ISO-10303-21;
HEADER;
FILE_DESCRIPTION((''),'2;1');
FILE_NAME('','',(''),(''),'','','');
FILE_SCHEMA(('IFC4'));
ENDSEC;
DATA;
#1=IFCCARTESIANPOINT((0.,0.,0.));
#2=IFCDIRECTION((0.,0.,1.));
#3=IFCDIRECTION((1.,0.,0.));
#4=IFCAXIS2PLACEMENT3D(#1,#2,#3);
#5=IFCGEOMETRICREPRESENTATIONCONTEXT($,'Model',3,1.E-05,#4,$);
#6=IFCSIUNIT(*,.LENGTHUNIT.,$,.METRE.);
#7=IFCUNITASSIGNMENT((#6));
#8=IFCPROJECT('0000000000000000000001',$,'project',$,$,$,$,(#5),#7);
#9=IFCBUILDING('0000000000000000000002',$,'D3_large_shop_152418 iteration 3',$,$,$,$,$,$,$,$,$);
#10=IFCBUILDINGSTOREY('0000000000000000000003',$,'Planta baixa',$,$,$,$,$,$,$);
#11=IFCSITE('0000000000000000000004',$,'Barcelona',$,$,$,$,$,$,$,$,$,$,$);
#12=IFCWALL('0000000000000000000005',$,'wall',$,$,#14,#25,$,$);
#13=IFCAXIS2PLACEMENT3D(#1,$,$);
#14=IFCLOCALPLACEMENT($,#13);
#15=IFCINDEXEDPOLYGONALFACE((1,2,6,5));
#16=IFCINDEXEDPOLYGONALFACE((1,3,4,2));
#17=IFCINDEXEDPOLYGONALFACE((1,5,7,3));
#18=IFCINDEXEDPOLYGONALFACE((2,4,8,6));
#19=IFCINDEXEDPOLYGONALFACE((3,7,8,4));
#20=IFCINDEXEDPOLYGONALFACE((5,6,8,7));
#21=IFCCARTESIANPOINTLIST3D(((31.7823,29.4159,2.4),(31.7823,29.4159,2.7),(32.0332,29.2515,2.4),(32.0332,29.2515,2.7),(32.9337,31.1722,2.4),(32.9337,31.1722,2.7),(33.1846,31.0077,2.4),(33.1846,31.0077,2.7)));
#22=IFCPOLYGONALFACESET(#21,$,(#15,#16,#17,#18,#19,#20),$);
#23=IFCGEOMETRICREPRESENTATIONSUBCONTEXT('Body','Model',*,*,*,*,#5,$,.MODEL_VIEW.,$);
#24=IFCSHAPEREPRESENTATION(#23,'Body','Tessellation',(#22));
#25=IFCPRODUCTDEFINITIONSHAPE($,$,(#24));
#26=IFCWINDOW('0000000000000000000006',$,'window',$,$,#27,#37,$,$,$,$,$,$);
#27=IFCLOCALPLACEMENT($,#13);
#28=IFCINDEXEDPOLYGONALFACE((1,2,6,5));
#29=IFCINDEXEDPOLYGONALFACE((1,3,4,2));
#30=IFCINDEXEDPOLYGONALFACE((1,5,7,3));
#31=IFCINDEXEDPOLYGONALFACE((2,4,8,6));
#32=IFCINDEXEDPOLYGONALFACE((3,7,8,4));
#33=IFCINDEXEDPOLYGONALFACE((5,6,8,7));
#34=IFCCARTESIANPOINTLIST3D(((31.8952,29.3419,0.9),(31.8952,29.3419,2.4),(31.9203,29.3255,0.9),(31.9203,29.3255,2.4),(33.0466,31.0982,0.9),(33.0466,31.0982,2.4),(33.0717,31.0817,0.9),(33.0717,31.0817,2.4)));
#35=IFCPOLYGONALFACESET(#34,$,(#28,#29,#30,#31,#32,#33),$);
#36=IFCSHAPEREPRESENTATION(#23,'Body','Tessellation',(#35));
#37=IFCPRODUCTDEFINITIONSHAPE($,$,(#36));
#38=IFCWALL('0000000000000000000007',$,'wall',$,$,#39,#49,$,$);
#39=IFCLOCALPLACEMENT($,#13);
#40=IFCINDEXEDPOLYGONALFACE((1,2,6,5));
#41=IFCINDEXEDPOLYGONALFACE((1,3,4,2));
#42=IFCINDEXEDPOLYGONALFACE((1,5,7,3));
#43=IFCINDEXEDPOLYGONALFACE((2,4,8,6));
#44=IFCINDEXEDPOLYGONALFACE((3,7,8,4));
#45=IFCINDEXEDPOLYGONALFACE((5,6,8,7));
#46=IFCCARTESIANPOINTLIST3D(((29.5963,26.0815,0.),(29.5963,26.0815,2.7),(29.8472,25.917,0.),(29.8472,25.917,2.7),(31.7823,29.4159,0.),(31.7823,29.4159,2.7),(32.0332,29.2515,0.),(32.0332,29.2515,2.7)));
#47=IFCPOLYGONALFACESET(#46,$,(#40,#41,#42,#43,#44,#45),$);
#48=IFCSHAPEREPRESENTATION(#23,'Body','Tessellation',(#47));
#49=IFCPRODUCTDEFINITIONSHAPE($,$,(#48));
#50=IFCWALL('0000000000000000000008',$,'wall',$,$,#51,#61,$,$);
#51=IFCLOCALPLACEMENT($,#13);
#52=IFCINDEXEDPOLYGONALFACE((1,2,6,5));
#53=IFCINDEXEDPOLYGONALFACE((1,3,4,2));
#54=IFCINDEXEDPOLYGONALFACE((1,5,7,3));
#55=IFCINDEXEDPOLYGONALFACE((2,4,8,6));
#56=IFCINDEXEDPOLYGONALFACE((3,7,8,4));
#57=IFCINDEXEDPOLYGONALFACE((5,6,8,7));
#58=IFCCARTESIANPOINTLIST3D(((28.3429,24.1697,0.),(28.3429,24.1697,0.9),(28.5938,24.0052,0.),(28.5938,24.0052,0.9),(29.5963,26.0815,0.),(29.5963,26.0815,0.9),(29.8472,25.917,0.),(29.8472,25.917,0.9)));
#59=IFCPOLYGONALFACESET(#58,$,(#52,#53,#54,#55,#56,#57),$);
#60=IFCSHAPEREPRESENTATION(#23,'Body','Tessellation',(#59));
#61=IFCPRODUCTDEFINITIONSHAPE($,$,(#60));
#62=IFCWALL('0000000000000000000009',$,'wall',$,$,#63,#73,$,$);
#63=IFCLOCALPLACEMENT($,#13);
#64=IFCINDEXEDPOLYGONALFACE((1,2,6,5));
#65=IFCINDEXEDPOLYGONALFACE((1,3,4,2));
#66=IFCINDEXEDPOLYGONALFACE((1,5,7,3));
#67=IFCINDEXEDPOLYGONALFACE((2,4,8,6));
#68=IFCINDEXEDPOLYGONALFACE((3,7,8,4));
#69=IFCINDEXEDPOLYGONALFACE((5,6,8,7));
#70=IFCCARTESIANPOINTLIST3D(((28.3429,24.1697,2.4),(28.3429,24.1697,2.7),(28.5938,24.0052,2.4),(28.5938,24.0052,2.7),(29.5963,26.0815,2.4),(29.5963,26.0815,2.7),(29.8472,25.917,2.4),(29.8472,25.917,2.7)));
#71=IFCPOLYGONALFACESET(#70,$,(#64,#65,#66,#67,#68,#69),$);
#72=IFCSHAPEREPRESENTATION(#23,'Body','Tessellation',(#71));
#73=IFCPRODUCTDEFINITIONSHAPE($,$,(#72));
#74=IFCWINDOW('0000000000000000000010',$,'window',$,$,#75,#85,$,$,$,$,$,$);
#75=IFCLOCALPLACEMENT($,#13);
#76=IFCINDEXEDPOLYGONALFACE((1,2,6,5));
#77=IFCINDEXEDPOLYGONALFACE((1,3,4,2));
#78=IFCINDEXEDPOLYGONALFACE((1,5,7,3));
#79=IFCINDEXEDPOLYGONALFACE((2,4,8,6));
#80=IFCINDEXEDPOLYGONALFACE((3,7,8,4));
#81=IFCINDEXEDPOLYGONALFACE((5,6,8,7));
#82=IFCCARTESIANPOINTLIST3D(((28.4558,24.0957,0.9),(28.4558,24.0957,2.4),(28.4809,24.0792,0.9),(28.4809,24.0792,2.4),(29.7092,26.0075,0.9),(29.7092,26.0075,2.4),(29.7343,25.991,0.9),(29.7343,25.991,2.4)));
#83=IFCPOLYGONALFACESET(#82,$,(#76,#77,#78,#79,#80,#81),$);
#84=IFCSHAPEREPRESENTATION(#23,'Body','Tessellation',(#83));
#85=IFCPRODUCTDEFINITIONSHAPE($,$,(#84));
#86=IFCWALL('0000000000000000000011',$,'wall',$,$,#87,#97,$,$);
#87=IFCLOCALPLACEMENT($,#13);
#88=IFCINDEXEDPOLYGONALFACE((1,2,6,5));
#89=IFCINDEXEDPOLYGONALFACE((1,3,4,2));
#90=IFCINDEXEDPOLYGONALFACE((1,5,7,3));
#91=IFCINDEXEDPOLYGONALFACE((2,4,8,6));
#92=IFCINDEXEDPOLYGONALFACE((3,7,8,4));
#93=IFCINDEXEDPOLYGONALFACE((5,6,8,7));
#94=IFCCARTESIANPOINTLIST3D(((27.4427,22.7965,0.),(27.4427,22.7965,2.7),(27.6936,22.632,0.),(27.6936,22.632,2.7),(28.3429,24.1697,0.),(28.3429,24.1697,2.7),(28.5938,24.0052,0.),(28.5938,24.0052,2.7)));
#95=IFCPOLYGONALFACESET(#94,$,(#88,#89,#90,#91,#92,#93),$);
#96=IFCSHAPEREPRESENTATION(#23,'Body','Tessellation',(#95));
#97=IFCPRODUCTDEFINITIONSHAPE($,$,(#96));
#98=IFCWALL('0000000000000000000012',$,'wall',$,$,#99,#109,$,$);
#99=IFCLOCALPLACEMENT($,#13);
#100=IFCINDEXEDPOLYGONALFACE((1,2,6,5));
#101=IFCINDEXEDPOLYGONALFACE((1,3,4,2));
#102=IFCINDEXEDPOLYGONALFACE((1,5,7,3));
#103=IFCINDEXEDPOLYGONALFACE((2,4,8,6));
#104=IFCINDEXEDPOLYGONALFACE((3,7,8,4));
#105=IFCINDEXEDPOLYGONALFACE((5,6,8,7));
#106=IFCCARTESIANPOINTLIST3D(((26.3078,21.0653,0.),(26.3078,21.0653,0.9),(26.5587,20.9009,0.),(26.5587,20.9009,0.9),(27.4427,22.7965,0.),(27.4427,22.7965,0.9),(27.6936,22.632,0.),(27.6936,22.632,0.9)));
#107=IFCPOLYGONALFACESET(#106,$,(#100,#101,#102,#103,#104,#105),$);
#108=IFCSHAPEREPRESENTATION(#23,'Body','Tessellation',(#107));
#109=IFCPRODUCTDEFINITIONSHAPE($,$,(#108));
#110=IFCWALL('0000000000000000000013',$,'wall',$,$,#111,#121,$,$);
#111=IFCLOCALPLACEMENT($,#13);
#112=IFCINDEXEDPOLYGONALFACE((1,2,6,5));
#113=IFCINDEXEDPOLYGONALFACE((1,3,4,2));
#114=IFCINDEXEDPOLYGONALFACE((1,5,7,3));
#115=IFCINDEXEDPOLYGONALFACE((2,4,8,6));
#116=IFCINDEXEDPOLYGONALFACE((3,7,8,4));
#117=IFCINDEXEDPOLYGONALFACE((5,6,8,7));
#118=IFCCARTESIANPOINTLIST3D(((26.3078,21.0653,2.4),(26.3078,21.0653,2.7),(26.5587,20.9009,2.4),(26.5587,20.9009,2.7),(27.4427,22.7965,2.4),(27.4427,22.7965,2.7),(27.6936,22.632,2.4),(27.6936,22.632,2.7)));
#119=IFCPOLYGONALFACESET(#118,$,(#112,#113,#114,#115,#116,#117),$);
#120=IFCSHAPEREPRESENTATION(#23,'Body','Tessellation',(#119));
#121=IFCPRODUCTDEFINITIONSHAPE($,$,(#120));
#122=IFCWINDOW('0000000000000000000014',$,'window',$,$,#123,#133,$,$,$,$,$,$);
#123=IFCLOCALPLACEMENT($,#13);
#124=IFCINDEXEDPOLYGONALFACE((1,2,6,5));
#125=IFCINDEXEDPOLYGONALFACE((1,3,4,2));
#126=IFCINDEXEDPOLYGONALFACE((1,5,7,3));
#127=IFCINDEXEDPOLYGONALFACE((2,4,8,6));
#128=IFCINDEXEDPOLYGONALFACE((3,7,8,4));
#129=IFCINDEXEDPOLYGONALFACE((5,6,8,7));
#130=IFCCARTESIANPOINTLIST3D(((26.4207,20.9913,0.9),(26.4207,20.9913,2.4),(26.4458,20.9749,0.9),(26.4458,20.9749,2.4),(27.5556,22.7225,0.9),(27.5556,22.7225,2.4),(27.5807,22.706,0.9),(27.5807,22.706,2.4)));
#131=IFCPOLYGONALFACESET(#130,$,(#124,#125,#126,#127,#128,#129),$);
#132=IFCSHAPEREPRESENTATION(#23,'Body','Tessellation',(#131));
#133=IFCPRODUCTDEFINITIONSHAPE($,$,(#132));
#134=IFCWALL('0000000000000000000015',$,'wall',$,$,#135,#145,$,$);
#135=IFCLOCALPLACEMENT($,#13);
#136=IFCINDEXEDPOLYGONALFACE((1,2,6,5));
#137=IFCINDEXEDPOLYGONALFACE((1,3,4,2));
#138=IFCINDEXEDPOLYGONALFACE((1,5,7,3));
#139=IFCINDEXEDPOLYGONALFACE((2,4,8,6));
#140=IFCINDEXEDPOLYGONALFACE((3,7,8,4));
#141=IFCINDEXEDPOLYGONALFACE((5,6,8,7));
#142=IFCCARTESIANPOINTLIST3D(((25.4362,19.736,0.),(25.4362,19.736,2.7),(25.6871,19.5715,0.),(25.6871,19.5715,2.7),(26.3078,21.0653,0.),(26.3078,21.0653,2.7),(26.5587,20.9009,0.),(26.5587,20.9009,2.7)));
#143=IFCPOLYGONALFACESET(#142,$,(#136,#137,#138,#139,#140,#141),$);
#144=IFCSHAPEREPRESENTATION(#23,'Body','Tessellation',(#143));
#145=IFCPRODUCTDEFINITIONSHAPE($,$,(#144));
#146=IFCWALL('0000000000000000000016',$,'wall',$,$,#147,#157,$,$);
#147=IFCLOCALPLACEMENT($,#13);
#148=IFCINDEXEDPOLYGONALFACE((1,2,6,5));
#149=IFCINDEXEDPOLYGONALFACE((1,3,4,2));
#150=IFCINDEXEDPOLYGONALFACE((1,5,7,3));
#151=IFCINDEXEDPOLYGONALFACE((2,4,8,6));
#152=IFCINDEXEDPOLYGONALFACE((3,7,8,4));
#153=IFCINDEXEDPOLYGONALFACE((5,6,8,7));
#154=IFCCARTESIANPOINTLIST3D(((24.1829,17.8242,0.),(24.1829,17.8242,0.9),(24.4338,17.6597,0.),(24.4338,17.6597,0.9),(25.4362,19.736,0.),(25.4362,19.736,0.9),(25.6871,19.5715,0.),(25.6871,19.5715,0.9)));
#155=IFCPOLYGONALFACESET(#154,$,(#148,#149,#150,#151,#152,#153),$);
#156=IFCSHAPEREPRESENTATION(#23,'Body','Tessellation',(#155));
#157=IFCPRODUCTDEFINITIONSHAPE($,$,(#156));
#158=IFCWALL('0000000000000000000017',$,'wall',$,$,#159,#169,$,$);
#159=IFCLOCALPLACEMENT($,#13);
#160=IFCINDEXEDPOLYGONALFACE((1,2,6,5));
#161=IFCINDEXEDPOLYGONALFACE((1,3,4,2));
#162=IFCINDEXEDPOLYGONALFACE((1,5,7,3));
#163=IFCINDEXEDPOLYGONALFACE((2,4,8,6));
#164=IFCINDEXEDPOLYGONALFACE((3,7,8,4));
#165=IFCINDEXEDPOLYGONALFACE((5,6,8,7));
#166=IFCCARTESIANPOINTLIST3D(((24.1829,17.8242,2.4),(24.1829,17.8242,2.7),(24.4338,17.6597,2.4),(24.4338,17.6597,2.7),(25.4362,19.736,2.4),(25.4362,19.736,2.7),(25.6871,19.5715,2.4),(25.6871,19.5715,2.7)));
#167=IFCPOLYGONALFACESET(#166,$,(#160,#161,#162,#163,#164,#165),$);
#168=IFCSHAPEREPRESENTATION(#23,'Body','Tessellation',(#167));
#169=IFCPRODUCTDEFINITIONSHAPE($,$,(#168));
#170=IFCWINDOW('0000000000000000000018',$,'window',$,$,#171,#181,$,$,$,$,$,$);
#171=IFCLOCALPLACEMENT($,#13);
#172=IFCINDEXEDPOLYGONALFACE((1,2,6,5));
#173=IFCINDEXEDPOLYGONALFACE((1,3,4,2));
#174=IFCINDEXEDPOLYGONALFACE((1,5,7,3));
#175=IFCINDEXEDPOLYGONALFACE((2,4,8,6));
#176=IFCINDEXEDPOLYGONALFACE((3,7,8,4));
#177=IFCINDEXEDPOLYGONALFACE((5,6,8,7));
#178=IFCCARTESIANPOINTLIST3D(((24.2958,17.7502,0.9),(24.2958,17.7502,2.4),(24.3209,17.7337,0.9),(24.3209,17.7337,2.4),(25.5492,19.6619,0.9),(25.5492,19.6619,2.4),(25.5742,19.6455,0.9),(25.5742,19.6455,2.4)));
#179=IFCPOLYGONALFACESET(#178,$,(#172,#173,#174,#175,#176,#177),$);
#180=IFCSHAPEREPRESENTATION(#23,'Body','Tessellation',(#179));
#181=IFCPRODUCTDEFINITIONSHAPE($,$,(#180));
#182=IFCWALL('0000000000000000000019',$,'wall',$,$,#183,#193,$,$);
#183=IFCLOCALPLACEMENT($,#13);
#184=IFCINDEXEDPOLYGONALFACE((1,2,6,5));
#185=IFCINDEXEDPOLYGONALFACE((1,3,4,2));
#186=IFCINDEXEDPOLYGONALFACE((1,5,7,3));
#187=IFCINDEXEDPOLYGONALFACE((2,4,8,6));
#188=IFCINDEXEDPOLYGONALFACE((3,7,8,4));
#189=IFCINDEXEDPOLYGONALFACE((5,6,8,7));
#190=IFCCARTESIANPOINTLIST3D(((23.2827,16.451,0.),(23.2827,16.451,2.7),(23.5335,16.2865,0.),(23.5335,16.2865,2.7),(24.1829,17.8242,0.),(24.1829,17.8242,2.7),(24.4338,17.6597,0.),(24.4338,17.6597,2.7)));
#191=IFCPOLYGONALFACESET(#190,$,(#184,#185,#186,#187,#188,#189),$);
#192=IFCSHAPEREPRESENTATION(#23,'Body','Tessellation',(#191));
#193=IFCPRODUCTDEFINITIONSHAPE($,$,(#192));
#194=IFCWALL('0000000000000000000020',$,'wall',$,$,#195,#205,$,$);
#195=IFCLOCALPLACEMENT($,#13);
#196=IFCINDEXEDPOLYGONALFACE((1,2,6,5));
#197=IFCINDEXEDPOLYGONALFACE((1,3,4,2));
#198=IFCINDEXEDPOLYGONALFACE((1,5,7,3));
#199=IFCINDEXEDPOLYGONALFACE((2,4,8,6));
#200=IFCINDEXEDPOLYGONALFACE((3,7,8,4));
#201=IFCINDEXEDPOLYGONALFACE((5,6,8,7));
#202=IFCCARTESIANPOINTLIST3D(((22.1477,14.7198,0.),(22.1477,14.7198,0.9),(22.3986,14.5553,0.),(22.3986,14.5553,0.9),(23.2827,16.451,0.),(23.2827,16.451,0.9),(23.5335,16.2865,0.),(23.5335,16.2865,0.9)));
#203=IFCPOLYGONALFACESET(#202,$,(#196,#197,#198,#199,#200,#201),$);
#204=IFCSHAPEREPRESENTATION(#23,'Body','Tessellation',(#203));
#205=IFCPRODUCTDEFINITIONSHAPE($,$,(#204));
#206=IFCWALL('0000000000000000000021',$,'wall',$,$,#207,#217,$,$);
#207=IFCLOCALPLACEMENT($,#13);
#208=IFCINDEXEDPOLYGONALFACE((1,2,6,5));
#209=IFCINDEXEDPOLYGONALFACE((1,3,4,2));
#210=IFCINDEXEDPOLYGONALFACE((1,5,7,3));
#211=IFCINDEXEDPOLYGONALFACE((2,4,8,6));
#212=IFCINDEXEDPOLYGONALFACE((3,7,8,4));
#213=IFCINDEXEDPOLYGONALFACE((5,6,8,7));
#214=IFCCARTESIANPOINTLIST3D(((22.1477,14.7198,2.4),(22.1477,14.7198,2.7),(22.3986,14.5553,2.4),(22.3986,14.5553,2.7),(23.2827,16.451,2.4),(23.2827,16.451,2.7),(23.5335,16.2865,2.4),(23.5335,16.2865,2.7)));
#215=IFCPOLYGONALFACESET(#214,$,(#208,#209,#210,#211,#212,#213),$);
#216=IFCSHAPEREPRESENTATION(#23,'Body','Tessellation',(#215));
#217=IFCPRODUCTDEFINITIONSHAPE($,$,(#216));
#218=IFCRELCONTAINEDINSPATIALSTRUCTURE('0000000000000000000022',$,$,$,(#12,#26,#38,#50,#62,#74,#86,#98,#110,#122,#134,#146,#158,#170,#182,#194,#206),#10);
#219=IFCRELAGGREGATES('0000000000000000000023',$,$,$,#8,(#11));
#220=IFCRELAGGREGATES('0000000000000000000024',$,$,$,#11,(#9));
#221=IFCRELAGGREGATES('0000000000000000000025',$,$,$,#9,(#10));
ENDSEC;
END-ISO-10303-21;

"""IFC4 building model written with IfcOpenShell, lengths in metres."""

from ifc_helpers import new_model, si_unit, frame, origin, origin_with_axes, place, context, subcontext, project, spatial, polyline, outline, extrude, element, save


model = new_model("IFC4")

# Units and contexts
model_context = context("Model", 3, precision=1e-05, world=origin_with_axes())
body_context = subcontext(model_context, "Body", "Model", "MODEL_VIEW")
ifc_project = project(units=[si_unit("LENGTHUNIT", "METRE")], contexts=[model_context])

# Site, building, storey
site = spatial("IfcSite", under=ifc_project, Name="Barcelona")
building = spatial("IfcBuilding", under=site, Name="D3_large_shop_152418 iteration 3")
storey = spatial("IfcBuildingStorey", under=building, Name="Planta baixa")

# Wall
wall_1_placement = place(None, origin_with_axes())
element("IfcWall", 1, at=wall_1_placement, inside=storey, Name="wall", context=body_context, shape_type="SweptSolid", body=[
    extrude(outline(polyline([(33.1846, 31.0077), (32.0332, 29.2515), (31.7823, 29.4159), (32.9337, 31.1722), (33.1846, 31.0077)])), frame((0.0, 0.0, 2.4)), (0.0, 0.0, 1.0), 0.3),
])

# Window
window_1_placement = place(None, origin_with_axes())
element("IfcWindow", 2, at=window_1_placement, inside=storey, Name="window", context=body_context, shape_type="SweptSolid", body=[
    extrude(outline(polyline([(33.0717, 31.0817), (31.9203, 29.3255), (31.8952, 29.3419), (33.0466, 31.0982), (33.0717, 31.0817)])), frame((0.0, 0.0, 0.9)), (0.0, 0.0, 1.0), 1.5),
])

# Walls
wall_2_placement = place(None, origin_with_axes())
element("IfcWall", 3, at=wall_2_placement, inside=storey, Name="wall", context=body_context, shape_type="SweptSolid", body=[
    extrude(outline(polyline([(32.0332, 29.2515), (29.8472, 25.917), (29.5963, 26.0815), (31.7823, 29.4159), (32.0332, 29.2515)])), origin(), (0.0, 0.0, 1.0), 2.7),
])
wall_3_placement = place(None, origin_with_axes())
element("IfcWall", 4, at=wall_3_placement, inside=storey, Name="wall", context=body_context, shape_type="SweptSolid", body=[
    extrude(outline(polyline([(29.8472, 25.917), (28.5938, 24.0052), (28.3429, 24.1697), (29.5963, 26.0815), (29.8472, 25.917)])), origin(), (0.0, 0.0, 1.0), 0.9),
])
wall_4_placement = place(None, origin_with_axes())
element("IfcWall", 5, at=wall_4_placement, inside=storey, Name="wall", context=body_context, shape_type="SweptSolid", body=[
    extrude(outline(polyline([(29.8472, 25.917), (28.5938, 24.0052), (28.3429, 24.1697), (29.5963, 26.0815), (29.8472, 25.917)])), frame((0.0, 0.0, 2.4)), (0.0, 0.0, 1.0), 0.3),
])

# Window
window_2_placement = place(None, origin_with_axes())
element("IfcWindow", 6, at=window_2_placement, inside=storey, Name="window", context=body_context, shape_type="SweptSolid", body=[
    extrude(outline(polyline([(29.7343, 25.991), (28.4809, 24.0792), (28.4558, 24.0957), (29.7092, 26.0075), (29.7343, 25.991)])), frame((0.0, 0.0, 0.9)), (0.0, 0.0, 1.0), 1.5),
])

# Walls
wall_5_placement = place(None, origin_with_axes())
element("IfcWall", 7, at=wall_5_placement, inside=storey, Name="wall", context=body_context, shape_type="SweptSolid", body=[
    extrude(outline(polyline([(28.5938, 24.0052), (27.6936, 22.632), (27.4427, 22.7965), (28.3429, 24.1697), (28.5938, 24.0052)])), origin(), (0.0, 0.0, 1.0), 2.7),
])
wall_6_placement = place(None, origin_with_axes())
element("IfcWall", 8, at=wall_6_placement, inside=storey, Name="wall", context=body_context, shape_type="SweptSolid", body=[
    extrude(outline(polyline([(27.6936, 22.632), (26.5587, 20.9009), (26.3078, 21.0653), (27.4427, 22.7965), (27.6936, 22.632)])), origin(), (0.0, 0.0, 1.0), 0.9),
])
wall_7_placement = place(None, origin_with_axes())
element("IfcWall", 9, at=wall_7_placement, inside=storey, Name="wall", context=body_context, shape_type="SweptSolid", body=[
    extrude(outline(polyline([(27.6936, 22.632), (26.5587, 20.9009), (26.3078, 21.0653), (27.4427, 22.7965), (27.6936, 22.632)])), frame((0.0, 0.0, 2.4)), (0.0, 0.0, 1.0), 0.3),
])

# Window
window_3_placement = place(None, origin_with_axes())
element("IfcWindow", 10, at=window_3_placement, inside=storey, Name="window", context=body_context, shape_type="SweptSolid", body=[
    extrude(outline(polyline([(27.5807, 22.706), (26.4458, 20.9749), (26.4207, 20.9913), (27.5556, 22.7225), (27.5807, 22.706)])), frame((0.0, 0.0, 0.9)), (0.0, 0.0, 1.0), 1.5),
])

# Walls
wall_8_placement = place(None, origin_with_axes())
element("IfcWall", 11, at=wall_8_placement, inside=storey, Name="wall", context=body_context, shape_type="SweptSolid", body=[
    extrude(outline(polyline([(26.5587, 20.9009), (25.6871, 19.5715), (25.4362, 19.736), (26.3078, 21.0653), (26.5587, 20.9009)])), origin(), (0.0, 0.0, 1.0), 2.7),
])
wall_9_placement = place(None, origin_with_axes())
element("IfcWall", 12, at=wall_9_placement, inside=storey, Name="wall", context=body_context, shape_type="SweptSolid", body=[
    extrude(outline(polyline([(25.6871, 19.5715), (24.4338, 17.6597), (24.1829, 17.8242), (25.4362, 19.736), (25.6871, 19.5715)])), origin(), (0.0, 0.0, 1.0), 0.9),
])
wall_10_placement = place(None, origin_with_axes())
element("IfcWall", 13, at=wall_10_placement, inside=storey, Name="wall", context=body_context, shape_type="SweptSolid", body=[
    extrude(outline(polyline([(25.6871, 19.5715), (24.4338, 17.6597), (24.1829, 17.8242), (25.4362, 19.736), (25.6871, 19.5715)])), frame((0.0, 0.0, 2.4)), (0.0, 0.0, 1.0), 0.3),
])

# Window
window_4_placement = place(None, origin_with_axes())
element("IfcWindow", 14, at=window_4_placement, inside=storey, Name="window", context=body_context, shape_type="SweptSolid", body=[
    extrude(outline(polyline([(25.5742, 19.6455), (24.3209, 17.7337), (24.2958, 17.7502), (25.5492, 19.6619), (25.5742, 19.6455)])), frame((0.0, 0.0, 0.9)), (0.0, 0.0, 1.0), 1.5),
])

# Walls
wall_11_placement = place(None, origin_with_axes())
element("IfcWall", 15, at=wall_11_placement, inside=storey, Name="wall", context=body_context, shape_type="SweptSolid", body=[
    extrude(outline(polyline([(24.4338, 17.6597), (23.5335, 16.2865), (23.2827, 16.451), (24.1829, 17.8242), (24.4338, 17.6597)])), origin(), (0.0, 0.0, 1.0), 2.7),
])
wall_12_placement = place(None, origin_with_axes())
element("IfcWall", 16, at=wall_12_placement, inside=storey, Name="wall", context=body_context, shape_type="SweptSolid", body=[
    extrude(outline(polyline([(23.5335, 16.2865), (22.3986, 14.5553), (22.1477, 14.7198), (23.2827, 16.451), (23.5335, 16.2865)])), origin(), (0.0, 0.0, 1.0), 0.9),
])
wall_13_placement = place(None, origin_with_axes())
element("IfcWall", 17, at=wall_13_placement, inside=storey, Name="wall", context=body_context, shape_type="SweptSolid", body=[
    extrude(outline(polyline([(23.5335, 16.2865), (22.3986, 14.5553), (22.1477, 14.7198), (23.2827, 16.451), (23.5335, 16.2865)])), frame((0.0, 0.0, 2.4)), (0.0, 0.0, 1.0), 0.3),
])

save(model, "model.ifc")
